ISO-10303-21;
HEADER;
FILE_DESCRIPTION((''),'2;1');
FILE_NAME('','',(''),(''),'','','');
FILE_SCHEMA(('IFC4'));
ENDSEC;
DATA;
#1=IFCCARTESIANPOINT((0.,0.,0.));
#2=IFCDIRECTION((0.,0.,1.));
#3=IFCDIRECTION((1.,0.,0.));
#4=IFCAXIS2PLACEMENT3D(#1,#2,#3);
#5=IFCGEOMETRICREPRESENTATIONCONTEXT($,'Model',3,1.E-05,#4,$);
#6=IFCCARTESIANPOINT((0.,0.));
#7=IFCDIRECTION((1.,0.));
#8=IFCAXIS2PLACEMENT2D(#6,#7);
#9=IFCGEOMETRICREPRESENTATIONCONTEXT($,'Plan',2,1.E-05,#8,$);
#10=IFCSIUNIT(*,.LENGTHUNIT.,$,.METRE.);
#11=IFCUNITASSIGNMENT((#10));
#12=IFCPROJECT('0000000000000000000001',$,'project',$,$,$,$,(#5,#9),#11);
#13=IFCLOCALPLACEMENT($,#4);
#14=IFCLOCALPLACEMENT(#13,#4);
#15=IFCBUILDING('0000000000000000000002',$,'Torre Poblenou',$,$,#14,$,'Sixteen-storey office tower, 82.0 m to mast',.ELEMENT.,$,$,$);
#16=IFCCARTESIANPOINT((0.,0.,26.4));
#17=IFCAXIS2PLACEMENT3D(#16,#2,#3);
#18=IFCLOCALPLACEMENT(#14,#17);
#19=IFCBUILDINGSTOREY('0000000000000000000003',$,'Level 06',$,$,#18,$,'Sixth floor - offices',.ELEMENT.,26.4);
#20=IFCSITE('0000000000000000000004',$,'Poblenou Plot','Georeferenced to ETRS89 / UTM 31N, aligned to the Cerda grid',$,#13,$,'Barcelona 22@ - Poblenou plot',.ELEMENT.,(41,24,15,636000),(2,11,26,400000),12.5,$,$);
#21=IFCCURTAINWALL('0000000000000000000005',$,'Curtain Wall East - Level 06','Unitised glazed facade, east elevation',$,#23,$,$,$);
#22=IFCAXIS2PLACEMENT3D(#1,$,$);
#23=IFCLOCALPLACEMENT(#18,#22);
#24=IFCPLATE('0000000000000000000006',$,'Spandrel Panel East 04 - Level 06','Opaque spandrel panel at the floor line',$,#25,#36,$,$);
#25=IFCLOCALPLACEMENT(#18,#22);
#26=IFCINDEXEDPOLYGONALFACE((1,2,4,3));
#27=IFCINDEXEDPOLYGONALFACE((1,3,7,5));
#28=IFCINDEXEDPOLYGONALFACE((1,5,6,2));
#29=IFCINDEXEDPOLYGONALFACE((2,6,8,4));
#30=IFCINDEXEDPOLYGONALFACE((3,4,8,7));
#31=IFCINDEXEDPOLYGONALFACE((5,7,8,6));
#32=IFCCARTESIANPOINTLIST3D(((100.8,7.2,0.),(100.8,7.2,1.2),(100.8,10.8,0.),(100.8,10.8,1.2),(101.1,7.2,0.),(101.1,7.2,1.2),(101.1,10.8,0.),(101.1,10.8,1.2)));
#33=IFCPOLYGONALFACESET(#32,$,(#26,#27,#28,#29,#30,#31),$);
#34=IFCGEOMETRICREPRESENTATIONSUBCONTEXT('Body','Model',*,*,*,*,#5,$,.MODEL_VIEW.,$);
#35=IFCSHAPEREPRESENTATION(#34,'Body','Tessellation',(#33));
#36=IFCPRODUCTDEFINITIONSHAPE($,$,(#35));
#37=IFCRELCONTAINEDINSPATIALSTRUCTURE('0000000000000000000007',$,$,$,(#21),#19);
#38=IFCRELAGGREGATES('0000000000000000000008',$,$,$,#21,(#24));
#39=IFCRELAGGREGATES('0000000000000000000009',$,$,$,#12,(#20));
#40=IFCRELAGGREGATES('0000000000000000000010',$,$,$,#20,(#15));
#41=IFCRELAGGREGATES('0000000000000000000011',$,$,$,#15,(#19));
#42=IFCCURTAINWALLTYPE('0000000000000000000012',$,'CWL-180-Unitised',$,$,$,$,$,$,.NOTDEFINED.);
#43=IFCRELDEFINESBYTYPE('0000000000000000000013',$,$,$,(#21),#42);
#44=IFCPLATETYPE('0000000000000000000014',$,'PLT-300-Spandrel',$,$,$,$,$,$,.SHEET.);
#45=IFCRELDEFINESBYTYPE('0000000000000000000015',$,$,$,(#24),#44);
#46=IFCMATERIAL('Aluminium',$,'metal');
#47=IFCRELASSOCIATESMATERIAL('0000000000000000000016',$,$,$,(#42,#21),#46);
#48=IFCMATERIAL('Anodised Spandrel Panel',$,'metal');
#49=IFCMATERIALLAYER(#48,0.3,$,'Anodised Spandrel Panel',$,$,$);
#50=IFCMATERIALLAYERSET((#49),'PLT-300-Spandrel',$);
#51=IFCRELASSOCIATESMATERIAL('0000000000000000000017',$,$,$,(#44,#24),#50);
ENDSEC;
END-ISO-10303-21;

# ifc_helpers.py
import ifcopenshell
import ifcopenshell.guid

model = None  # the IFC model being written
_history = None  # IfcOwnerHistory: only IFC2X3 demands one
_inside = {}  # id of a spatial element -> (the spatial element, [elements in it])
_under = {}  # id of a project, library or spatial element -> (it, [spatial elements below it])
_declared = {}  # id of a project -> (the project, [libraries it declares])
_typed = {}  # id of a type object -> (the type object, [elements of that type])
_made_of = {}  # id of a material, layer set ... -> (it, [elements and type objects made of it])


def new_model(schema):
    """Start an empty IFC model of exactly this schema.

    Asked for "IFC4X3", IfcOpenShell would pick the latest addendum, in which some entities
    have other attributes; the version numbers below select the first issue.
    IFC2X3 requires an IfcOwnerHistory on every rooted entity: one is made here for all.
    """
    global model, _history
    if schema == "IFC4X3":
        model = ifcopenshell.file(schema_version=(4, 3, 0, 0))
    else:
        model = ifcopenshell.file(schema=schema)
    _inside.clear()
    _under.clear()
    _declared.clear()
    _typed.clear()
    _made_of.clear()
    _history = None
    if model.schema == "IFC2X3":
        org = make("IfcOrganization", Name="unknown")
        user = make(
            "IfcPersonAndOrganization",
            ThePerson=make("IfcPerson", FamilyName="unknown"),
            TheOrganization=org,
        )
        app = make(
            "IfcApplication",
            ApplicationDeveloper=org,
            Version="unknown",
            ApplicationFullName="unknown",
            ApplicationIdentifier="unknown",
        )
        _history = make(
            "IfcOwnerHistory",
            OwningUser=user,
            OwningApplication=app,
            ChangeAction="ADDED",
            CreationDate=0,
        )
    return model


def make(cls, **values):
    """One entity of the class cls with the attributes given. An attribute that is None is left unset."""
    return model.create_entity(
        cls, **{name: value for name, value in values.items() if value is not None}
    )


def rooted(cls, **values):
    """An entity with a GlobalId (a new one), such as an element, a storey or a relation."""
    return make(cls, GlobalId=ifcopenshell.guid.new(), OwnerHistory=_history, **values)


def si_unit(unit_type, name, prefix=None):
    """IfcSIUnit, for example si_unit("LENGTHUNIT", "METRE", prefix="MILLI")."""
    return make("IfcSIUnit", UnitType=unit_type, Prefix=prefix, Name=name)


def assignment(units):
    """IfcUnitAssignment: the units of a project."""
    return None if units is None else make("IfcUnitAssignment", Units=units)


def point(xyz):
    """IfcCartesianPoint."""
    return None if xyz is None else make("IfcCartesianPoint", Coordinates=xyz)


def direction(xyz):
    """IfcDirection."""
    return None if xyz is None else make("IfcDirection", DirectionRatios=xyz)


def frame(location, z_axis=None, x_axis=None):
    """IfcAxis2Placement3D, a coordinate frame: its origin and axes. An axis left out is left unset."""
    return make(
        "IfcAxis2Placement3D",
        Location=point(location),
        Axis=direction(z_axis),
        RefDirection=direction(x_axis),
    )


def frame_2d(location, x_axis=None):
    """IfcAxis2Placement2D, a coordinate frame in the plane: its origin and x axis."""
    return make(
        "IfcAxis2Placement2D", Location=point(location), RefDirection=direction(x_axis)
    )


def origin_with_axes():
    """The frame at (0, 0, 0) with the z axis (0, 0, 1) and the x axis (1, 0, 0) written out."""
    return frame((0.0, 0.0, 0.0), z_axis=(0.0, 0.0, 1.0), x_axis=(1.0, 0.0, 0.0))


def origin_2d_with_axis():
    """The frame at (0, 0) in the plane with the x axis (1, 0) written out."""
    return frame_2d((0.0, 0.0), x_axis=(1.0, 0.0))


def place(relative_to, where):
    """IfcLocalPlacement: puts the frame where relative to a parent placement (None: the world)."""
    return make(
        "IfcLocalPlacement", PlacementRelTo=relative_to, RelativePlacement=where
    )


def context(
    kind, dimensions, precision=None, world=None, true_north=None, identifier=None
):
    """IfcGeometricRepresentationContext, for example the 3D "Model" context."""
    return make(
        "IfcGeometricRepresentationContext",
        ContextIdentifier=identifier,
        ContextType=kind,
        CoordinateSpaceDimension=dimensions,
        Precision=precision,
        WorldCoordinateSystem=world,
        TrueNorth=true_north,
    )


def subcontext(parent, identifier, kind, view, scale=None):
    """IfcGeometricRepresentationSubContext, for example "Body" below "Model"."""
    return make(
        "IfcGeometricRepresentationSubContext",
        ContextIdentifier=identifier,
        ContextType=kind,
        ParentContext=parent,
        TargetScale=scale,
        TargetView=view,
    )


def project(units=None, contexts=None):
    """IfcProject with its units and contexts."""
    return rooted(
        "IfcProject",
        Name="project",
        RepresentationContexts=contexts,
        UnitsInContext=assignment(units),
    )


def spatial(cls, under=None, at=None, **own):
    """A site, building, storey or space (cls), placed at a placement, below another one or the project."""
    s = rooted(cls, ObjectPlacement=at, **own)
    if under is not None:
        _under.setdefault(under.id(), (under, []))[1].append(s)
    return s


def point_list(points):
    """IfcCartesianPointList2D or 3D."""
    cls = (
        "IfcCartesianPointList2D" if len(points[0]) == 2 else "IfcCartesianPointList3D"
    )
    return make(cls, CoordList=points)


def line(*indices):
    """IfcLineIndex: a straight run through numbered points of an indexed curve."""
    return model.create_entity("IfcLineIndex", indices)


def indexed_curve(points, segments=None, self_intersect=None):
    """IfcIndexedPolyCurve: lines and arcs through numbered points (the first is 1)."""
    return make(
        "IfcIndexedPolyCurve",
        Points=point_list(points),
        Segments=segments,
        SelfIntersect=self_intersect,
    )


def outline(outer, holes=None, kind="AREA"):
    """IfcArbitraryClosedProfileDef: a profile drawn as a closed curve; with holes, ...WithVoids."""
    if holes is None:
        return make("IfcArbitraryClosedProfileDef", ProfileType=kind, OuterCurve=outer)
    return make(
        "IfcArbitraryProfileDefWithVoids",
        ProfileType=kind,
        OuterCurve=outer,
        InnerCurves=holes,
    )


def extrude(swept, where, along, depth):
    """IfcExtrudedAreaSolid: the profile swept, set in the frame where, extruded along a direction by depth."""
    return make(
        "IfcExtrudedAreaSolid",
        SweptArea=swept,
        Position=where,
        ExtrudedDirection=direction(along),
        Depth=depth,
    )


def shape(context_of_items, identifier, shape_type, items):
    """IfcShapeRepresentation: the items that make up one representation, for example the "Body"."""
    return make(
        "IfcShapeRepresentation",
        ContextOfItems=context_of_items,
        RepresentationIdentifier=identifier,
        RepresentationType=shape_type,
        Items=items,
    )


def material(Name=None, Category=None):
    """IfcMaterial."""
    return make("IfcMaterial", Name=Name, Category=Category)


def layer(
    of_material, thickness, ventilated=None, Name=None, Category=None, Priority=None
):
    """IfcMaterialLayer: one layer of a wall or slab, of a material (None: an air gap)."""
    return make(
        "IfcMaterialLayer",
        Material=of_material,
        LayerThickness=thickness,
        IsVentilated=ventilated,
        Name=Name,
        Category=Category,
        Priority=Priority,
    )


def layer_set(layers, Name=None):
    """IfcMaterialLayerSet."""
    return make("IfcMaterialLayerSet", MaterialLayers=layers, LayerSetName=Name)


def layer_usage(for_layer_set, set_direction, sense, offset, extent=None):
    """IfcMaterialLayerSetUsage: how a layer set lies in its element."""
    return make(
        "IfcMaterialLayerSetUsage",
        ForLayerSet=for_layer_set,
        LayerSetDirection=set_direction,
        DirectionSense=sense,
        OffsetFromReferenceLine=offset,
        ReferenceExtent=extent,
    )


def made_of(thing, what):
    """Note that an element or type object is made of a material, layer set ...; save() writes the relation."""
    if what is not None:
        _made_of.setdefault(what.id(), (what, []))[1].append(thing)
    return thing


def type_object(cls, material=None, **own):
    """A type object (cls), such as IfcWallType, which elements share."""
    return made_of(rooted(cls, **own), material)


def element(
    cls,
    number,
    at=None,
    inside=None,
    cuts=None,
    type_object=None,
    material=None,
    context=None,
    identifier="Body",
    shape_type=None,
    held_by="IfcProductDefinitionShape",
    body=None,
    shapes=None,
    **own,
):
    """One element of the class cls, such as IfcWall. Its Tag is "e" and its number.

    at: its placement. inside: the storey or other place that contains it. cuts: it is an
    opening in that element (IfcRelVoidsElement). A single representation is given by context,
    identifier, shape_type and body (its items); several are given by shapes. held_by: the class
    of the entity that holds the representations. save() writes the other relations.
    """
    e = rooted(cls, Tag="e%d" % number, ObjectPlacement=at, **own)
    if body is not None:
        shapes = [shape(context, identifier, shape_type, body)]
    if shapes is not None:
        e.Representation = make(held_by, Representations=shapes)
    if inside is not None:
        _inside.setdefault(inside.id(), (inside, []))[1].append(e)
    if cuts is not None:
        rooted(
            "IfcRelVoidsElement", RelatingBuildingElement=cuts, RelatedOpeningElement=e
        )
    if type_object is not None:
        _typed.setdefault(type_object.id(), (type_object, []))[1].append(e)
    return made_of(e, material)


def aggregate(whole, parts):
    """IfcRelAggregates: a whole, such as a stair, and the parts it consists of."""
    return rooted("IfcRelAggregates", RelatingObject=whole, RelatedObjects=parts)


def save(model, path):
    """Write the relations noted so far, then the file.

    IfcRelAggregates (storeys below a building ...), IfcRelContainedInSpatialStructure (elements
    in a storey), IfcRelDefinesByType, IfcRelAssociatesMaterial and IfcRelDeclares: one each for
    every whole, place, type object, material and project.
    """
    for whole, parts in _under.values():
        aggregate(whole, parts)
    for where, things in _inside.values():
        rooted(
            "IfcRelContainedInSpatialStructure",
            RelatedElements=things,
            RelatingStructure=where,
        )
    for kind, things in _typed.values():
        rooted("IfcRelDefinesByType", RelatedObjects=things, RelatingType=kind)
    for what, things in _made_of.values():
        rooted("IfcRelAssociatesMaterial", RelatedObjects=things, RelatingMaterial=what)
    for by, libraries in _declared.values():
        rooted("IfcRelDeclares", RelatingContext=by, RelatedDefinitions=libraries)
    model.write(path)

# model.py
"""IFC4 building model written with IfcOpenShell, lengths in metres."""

from ifc_helpers import new_model, si_unit, frame, origin_with_axes, origin_2d_with_axis, place, context, subcontext, project, spatial, line, indexed_curve, outline, extrude, material, layer, layer_set, layer_usage, type_object, element, aggregate, save


model = new_model("IFC4")

# Units and contexts
model_context = context("Model", 3, precision=1e-05, world=origin_with_axes())
plan_context = context("Plan", 2, precision=1e-05, world=origin_2d_with_axis())
body_context = subcontext(model_context, "Body", "Model", "MODEL_VIEW")
ifc_project = project(units=[si_unit("LENGTHUNIT", "METRE")], contexts=[model_context, plan_context])

# Site, building, storey
site_placement = place(None, origin_with_axes())
site = spatial("IfcSite", under=ifc_project, at=site_placement, Name="Poblenou Plot", Description="Georeferenced to ETRS89 / UTM 31N, aligned to the Cerda grid", LongName="Barcelona 22@ - Poblenou plot", CompositionType="ELEMENT", RefLatitude=(41, 24, 15, 636000), RefLongitude=(2, 11, 26, 400000), RefElevation=12.5)
building_placement = place(site_placement, origin_with_axes())
building = spatial("IfcBuilding", under=site, at=building_placement, Name="Torre Poblenou", LongName="Sixteen-storey office tower, 82.0 m to mast", CompositionType="ELEMENT")
storey_placement = place(building_placement, frame((0.0, 0.0, 26.4), z_axis=(0.0, 0.0, 1.0), x_axis=(1.0, 0.0, 0.0)))
storey = spatial("IfcBuildingStorey", under=building, at=storey_placement, Name="Level 06", LongName="Sixth floor - offices", CompositionType="ELEMENT", Elevation=26.4)

# Curtain wall
ifc_material_1 = material(Name="Aluminium", Category="metal")
curtain_wall_type = type_object("IfcCurtainWallType", Name="CWL-180-Unitised", PredefinedType="NOTDEFINED", material=ifc_material_1)
curtain_wall_1_placement = place(storey_placement, frame((100.8, 21.6, 0.0), z_axis=(0.0, 0.0, 1.0), x_axis=(0.0, -1.0, 0.0)))
curtain_wall_1 = element("IfcCurtainWall", 1, at=curtain_wall_1_placement, inside=storey, type_object=curtain_wall_type, material=ifc_material_1, Name="Curtain Wall East - Level 06", Description="Unitised glazed facade, east elevation")

# Plate
ifc_material_2 = material(Name="Anodised Spandrel Panel", Category="metal")
ifc_layer_1 = layer(ifc_material_2, 0.3, Name="Anodised Spandrel Panel")
ifc_layer_set_1 = layer_set([ifc_layer_1], Name="PLT-300-Spandrel")
plate_type_1 = type_object("IfcPlateType", Name="PLT-300-Spandrel", PredefinedType="SHEET", material=ifc_layer_set_1)
ifc_layer_usage_1 = layer_usage(ifc_layer_set_1, "AXIS2", "POSITIVE", 0.0)
plate_1_placement = place(curtain_wall_1_placement, frame((10.8, 0.0, 0.0), z_axis=(0.0, 0.0, 1.0), x_axis=(1.0, 0.0, 0.0)))
plate_1 = element("IfcPlate", 2, at=plate_1_placement, type_object=plate_type_1, material=ifc_layer_usage_1, Name="Spandrel Panel East 04 - Level 06", Description="Opaque spandrel panel at the floor line", context=body_context, shape_type="SweptSolid", body=[
    extrude(outline(indexed_curve([(0.0, 0.0), (3.6, 0.0), (3.6, 0.3), (0.0, 0.3)], segments=[line(1, 2, 3, 4, 1)])), origin_with_axes(), (0.0, 0.0, 1.0), 1.2),
])
aggregate(curtain_wall_1, [plate_1])

save(model, "model.ifc")
